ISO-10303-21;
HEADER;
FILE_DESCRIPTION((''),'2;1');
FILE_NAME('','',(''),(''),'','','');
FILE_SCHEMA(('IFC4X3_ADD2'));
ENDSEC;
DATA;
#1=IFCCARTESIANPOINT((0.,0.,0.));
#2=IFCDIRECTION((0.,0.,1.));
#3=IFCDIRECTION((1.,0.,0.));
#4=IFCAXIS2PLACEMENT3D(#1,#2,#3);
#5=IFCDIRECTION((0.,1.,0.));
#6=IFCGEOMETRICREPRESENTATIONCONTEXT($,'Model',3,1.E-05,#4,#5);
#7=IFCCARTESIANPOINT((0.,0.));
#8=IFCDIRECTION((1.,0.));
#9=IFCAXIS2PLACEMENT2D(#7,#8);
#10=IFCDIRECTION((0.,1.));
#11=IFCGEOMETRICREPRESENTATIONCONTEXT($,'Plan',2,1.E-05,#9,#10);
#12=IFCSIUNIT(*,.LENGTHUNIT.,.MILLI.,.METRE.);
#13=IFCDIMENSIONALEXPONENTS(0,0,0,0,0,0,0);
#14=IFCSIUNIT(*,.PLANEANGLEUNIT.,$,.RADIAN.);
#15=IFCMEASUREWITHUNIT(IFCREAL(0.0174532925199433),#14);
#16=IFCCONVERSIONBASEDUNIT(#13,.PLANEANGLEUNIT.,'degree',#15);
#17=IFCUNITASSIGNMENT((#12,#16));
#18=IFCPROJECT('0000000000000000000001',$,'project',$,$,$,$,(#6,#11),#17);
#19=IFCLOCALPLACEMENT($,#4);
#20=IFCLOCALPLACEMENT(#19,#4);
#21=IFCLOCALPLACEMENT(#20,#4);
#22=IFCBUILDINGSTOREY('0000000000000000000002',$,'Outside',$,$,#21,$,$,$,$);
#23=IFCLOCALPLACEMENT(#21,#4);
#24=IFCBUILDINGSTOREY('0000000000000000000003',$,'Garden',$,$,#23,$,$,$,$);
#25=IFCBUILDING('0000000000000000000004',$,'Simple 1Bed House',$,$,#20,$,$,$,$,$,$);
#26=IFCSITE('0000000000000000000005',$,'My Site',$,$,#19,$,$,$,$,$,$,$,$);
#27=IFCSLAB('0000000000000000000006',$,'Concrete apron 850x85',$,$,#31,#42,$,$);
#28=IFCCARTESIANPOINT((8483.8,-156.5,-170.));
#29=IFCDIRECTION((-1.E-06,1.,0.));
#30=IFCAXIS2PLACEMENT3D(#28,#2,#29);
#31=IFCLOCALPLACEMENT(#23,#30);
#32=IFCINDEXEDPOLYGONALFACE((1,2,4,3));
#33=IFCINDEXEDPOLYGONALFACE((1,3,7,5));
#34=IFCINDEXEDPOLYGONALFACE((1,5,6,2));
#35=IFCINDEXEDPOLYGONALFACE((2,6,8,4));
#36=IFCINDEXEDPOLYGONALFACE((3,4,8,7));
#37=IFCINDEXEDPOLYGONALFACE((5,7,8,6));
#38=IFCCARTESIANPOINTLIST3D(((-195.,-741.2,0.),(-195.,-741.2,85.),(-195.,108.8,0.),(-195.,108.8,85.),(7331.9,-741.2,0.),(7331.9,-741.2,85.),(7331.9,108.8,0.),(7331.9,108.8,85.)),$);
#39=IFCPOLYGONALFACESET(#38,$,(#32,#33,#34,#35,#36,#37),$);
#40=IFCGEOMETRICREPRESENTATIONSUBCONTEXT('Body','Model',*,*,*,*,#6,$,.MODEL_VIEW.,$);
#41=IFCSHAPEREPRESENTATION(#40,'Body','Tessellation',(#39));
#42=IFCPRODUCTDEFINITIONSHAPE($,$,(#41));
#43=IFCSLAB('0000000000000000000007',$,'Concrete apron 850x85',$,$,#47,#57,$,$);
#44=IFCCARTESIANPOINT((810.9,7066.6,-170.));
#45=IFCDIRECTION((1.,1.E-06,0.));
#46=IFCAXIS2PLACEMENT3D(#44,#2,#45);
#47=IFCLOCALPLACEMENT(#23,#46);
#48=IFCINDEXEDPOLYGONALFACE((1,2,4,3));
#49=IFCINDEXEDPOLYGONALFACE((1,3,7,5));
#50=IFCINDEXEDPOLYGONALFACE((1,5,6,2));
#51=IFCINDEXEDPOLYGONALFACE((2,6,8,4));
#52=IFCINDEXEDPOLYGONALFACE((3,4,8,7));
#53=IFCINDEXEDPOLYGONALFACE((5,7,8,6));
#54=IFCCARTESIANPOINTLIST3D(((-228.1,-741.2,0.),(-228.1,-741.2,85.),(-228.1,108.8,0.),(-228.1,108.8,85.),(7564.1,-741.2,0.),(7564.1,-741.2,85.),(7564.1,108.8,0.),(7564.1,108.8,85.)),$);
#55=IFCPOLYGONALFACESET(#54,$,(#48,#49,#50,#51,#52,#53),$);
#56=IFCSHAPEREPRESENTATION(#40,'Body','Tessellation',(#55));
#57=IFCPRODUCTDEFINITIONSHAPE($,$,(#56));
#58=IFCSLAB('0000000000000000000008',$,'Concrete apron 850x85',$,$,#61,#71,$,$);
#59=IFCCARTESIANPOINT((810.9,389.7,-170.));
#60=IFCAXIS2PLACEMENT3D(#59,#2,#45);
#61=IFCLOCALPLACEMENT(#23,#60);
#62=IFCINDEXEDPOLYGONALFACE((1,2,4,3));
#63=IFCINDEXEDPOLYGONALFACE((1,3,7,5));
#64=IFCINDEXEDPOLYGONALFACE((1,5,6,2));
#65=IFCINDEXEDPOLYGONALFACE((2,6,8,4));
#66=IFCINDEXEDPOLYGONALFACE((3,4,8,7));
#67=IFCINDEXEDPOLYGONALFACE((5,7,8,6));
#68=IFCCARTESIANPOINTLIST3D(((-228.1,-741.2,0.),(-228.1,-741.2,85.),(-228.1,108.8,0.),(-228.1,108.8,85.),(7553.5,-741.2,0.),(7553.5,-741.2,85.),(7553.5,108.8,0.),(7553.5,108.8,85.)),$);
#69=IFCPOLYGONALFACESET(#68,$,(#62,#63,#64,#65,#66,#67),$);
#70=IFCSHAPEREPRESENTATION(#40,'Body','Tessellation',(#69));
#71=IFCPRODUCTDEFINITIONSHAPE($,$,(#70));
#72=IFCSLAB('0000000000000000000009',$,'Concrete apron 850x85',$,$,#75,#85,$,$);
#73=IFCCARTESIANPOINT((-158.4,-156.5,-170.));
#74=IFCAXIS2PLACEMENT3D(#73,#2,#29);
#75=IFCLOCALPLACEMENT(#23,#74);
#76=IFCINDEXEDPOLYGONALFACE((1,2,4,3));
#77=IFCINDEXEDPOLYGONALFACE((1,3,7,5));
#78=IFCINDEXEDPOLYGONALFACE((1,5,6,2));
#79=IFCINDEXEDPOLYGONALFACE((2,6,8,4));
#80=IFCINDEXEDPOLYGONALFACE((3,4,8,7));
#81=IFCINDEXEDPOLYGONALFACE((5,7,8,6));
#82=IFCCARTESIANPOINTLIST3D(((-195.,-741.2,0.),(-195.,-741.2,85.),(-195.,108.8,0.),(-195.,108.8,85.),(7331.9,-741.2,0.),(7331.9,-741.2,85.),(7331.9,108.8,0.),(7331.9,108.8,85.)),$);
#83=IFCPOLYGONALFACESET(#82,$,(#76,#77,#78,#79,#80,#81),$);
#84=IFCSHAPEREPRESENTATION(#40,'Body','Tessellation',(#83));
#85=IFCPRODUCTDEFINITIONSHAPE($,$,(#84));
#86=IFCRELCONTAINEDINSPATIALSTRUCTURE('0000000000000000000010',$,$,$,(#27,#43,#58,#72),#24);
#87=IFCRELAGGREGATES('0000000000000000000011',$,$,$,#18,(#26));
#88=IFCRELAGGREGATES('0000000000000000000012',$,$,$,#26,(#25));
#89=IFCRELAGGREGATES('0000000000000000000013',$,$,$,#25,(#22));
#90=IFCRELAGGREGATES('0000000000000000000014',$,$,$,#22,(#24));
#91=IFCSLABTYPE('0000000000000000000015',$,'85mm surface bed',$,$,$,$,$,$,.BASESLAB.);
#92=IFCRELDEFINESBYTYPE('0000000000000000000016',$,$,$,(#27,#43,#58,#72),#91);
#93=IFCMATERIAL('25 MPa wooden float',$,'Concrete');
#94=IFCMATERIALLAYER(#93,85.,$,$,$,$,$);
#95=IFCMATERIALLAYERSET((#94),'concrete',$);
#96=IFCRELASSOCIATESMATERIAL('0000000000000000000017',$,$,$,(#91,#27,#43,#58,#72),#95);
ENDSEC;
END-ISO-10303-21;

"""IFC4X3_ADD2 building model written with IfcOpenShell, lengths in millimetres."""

from ifc_helpers import new_model, entity, si_unit, converted_unit, direction, frame, origin_with_axes, origin_2d_with_axis, place, context, subcontext, project, spatial, indexed_curve, outline, extrude, material, layer, layer_set, layer_usage, type_object, element, save


model = new_model("IFC4X3_ADD2")

# Units and contexts
model_context = context("Model", 3, precision=1e-05, world=origin_with_axes(), true_north=direction((0.0, 1.0, 0.0)))
plan_context = context("Plan", 2, precision=1e-05, world=origin_2d_with_axis(), true_north=direction((0.0, 1.0)))
body_context = subcontext(model_context, "Body", "Model", "MODEL_VIEW")
ifc_project = project(units=[si_unit("LENGTHUNIT", "METRE", prefix="MILLI"), converted_unit("PLANEANGLEUNIT", "degree", entity("IfcReal", 0.0174532925199433), si_unit("PLANEANGLEUNIT", "RADIAN"), dimensions=[0, 0, 0, 0, 0, 0, 0])], contexts=[model_context, plan_context])

# Site, building, storeys
site_placement = place(None, origin_with_axes())
site = spatial("IfcSite", under=ifc_project, at=site_placement, Name="My Site")
building_placement = place(site_placement, origin_with_axes())
building = spatial("IfcBuilding", under=site, at=building_placement, Name="Simple 1Bed House")
storey_1_placement = place(building_placement, origin_with_axes())
storey_1 = spatial("IfcBuildingStorey", under=building, at=storey_1_placement, Name="Outside")
storey_2_placement = place(storey_1_placement, origin_with_axes())
storey_2 = spatial("IfcBuildingStorey", under=storey_1, at=storey_2_placement, Name="Garden")

# Slabs
ifc_material_1 = material(Name="25 MPa wooden float", Category="Concrete")
ifc_layer_1 = layer(ifc_material_1, 85.0)
ifc_layer_set_1 = layer_set([ifc_layer_1], Name="concrete")
ifc_layer_usage_1 = layer_usage(ifc_layer_set_1, "AXIS3", "POSITIVE", 0.0)
slab_type = type_object("IfcSlabType", Name="85mm surface bed", PredefinedType="BASESLAB", material=ifc_layer_set_1)
slab_1_placement = place(storey_2_placement, frame((8483.8, -156.5, -170.0), z_axis=(0.0, 0.0, 1.0), x_axis=(-0.000001, 1.0, 0.0)))
element("IfcSlab", 1, at=slab_1_placement, inside=storey_2, type_object=slab_type, material=ifc_layer_usage_1, Name="Concrete apron 850x85", context=body_context, shape_type="SweptSolid", body=[
    extrude(outline(indexed_curve([(-195.0, -741.2), (-195.0, 108.8), (7331.9, 108.8), (7331.9, -741.2), (-195.0, -741.2)])), None, (0.0, 0.0, 1.0), 85.0),
])
ifc_layer_usage_2 = layer_usage(ifc_layer_set_1, "AXIS3", "POSITIVE", 0.0)
slab_2_placement = place(storey_2_placement, frame((810.9, 7066.6, -170.0), z_axis=(0.0, 0.0, 1.0), x_axis=(1.0, 0.000001, 0.0)))
element("IfcSlab", 2, at=slab_2_placement, inside=storey_2, type_object=slab_type, material=ifc_layer_usage_2, Name="Concrete apron 850x85", context=body_context, shape_type="SolidModel", body=[
    extrude(outline(indexed_curve([(7564.1, -741.2), (-228.1, -741.2), (-228.1, 108.8), (7564.1, 108.8), (7564.1, -741.2)])), None, (0.0, 0.0, 1.0), 85.0),
])
ifc_layer_usage_3 = layer_usage(ifc_layer_set_1, "AXIS3", "POSITIVE", 0.0)
slab_3_placement = place(storey_2_placement, frame((810.9, 389.7, -170.0), z_axis=(0.0, 0.0, 1.0), x_axis=(1.0, 0.000001, 0.0)))
element("IfcSlab", 3, at=slab_3_placement, inside=storey_2, type_object=slab_type, material=ifc_layer_usage_3, Name="Concrete apron 850x85", context=body_context, shape_type="SweptSolid", body=[
    extrude(outline(indexed_curve([(7553.5, -741.2), (7553.5, 108.8), (-228.1, 108.8), (-228.1, -741.2), (7553.5, -741.2)])), None, (0.0, 0.0, 1.0), 85.0),
])
ifc_layer_usage_4 = layer_usage(ifc_layer_set_1, "AXIS3", "POSITIVE", 0.0)
slab_4_placement = place(storey_2_placement, frame((-158.4, -156.5, -170.0), z_axis=(0.0, 0.0, 1.0), x_axis=(-0.000001, 1.0, 0.0)))
element("IfcSlab", 4, at=slab_4_placement, inside=storey_2, type_object=slab_type, material=ifc_layer_usage_4, Name="Concrete apron 850x85", context=body_context, shape_type="SweptSolid", body=[
    extrude(outline(indexed_curve([(7331.9, -741.2), (-195.0, -741.2), (-195.0, 108.8), (7331.9, 108.8), (7331.9, -741.2)])), None, (0.0, 0.0, 1.0), 85.0),
])

save(model, "model.ifc")
